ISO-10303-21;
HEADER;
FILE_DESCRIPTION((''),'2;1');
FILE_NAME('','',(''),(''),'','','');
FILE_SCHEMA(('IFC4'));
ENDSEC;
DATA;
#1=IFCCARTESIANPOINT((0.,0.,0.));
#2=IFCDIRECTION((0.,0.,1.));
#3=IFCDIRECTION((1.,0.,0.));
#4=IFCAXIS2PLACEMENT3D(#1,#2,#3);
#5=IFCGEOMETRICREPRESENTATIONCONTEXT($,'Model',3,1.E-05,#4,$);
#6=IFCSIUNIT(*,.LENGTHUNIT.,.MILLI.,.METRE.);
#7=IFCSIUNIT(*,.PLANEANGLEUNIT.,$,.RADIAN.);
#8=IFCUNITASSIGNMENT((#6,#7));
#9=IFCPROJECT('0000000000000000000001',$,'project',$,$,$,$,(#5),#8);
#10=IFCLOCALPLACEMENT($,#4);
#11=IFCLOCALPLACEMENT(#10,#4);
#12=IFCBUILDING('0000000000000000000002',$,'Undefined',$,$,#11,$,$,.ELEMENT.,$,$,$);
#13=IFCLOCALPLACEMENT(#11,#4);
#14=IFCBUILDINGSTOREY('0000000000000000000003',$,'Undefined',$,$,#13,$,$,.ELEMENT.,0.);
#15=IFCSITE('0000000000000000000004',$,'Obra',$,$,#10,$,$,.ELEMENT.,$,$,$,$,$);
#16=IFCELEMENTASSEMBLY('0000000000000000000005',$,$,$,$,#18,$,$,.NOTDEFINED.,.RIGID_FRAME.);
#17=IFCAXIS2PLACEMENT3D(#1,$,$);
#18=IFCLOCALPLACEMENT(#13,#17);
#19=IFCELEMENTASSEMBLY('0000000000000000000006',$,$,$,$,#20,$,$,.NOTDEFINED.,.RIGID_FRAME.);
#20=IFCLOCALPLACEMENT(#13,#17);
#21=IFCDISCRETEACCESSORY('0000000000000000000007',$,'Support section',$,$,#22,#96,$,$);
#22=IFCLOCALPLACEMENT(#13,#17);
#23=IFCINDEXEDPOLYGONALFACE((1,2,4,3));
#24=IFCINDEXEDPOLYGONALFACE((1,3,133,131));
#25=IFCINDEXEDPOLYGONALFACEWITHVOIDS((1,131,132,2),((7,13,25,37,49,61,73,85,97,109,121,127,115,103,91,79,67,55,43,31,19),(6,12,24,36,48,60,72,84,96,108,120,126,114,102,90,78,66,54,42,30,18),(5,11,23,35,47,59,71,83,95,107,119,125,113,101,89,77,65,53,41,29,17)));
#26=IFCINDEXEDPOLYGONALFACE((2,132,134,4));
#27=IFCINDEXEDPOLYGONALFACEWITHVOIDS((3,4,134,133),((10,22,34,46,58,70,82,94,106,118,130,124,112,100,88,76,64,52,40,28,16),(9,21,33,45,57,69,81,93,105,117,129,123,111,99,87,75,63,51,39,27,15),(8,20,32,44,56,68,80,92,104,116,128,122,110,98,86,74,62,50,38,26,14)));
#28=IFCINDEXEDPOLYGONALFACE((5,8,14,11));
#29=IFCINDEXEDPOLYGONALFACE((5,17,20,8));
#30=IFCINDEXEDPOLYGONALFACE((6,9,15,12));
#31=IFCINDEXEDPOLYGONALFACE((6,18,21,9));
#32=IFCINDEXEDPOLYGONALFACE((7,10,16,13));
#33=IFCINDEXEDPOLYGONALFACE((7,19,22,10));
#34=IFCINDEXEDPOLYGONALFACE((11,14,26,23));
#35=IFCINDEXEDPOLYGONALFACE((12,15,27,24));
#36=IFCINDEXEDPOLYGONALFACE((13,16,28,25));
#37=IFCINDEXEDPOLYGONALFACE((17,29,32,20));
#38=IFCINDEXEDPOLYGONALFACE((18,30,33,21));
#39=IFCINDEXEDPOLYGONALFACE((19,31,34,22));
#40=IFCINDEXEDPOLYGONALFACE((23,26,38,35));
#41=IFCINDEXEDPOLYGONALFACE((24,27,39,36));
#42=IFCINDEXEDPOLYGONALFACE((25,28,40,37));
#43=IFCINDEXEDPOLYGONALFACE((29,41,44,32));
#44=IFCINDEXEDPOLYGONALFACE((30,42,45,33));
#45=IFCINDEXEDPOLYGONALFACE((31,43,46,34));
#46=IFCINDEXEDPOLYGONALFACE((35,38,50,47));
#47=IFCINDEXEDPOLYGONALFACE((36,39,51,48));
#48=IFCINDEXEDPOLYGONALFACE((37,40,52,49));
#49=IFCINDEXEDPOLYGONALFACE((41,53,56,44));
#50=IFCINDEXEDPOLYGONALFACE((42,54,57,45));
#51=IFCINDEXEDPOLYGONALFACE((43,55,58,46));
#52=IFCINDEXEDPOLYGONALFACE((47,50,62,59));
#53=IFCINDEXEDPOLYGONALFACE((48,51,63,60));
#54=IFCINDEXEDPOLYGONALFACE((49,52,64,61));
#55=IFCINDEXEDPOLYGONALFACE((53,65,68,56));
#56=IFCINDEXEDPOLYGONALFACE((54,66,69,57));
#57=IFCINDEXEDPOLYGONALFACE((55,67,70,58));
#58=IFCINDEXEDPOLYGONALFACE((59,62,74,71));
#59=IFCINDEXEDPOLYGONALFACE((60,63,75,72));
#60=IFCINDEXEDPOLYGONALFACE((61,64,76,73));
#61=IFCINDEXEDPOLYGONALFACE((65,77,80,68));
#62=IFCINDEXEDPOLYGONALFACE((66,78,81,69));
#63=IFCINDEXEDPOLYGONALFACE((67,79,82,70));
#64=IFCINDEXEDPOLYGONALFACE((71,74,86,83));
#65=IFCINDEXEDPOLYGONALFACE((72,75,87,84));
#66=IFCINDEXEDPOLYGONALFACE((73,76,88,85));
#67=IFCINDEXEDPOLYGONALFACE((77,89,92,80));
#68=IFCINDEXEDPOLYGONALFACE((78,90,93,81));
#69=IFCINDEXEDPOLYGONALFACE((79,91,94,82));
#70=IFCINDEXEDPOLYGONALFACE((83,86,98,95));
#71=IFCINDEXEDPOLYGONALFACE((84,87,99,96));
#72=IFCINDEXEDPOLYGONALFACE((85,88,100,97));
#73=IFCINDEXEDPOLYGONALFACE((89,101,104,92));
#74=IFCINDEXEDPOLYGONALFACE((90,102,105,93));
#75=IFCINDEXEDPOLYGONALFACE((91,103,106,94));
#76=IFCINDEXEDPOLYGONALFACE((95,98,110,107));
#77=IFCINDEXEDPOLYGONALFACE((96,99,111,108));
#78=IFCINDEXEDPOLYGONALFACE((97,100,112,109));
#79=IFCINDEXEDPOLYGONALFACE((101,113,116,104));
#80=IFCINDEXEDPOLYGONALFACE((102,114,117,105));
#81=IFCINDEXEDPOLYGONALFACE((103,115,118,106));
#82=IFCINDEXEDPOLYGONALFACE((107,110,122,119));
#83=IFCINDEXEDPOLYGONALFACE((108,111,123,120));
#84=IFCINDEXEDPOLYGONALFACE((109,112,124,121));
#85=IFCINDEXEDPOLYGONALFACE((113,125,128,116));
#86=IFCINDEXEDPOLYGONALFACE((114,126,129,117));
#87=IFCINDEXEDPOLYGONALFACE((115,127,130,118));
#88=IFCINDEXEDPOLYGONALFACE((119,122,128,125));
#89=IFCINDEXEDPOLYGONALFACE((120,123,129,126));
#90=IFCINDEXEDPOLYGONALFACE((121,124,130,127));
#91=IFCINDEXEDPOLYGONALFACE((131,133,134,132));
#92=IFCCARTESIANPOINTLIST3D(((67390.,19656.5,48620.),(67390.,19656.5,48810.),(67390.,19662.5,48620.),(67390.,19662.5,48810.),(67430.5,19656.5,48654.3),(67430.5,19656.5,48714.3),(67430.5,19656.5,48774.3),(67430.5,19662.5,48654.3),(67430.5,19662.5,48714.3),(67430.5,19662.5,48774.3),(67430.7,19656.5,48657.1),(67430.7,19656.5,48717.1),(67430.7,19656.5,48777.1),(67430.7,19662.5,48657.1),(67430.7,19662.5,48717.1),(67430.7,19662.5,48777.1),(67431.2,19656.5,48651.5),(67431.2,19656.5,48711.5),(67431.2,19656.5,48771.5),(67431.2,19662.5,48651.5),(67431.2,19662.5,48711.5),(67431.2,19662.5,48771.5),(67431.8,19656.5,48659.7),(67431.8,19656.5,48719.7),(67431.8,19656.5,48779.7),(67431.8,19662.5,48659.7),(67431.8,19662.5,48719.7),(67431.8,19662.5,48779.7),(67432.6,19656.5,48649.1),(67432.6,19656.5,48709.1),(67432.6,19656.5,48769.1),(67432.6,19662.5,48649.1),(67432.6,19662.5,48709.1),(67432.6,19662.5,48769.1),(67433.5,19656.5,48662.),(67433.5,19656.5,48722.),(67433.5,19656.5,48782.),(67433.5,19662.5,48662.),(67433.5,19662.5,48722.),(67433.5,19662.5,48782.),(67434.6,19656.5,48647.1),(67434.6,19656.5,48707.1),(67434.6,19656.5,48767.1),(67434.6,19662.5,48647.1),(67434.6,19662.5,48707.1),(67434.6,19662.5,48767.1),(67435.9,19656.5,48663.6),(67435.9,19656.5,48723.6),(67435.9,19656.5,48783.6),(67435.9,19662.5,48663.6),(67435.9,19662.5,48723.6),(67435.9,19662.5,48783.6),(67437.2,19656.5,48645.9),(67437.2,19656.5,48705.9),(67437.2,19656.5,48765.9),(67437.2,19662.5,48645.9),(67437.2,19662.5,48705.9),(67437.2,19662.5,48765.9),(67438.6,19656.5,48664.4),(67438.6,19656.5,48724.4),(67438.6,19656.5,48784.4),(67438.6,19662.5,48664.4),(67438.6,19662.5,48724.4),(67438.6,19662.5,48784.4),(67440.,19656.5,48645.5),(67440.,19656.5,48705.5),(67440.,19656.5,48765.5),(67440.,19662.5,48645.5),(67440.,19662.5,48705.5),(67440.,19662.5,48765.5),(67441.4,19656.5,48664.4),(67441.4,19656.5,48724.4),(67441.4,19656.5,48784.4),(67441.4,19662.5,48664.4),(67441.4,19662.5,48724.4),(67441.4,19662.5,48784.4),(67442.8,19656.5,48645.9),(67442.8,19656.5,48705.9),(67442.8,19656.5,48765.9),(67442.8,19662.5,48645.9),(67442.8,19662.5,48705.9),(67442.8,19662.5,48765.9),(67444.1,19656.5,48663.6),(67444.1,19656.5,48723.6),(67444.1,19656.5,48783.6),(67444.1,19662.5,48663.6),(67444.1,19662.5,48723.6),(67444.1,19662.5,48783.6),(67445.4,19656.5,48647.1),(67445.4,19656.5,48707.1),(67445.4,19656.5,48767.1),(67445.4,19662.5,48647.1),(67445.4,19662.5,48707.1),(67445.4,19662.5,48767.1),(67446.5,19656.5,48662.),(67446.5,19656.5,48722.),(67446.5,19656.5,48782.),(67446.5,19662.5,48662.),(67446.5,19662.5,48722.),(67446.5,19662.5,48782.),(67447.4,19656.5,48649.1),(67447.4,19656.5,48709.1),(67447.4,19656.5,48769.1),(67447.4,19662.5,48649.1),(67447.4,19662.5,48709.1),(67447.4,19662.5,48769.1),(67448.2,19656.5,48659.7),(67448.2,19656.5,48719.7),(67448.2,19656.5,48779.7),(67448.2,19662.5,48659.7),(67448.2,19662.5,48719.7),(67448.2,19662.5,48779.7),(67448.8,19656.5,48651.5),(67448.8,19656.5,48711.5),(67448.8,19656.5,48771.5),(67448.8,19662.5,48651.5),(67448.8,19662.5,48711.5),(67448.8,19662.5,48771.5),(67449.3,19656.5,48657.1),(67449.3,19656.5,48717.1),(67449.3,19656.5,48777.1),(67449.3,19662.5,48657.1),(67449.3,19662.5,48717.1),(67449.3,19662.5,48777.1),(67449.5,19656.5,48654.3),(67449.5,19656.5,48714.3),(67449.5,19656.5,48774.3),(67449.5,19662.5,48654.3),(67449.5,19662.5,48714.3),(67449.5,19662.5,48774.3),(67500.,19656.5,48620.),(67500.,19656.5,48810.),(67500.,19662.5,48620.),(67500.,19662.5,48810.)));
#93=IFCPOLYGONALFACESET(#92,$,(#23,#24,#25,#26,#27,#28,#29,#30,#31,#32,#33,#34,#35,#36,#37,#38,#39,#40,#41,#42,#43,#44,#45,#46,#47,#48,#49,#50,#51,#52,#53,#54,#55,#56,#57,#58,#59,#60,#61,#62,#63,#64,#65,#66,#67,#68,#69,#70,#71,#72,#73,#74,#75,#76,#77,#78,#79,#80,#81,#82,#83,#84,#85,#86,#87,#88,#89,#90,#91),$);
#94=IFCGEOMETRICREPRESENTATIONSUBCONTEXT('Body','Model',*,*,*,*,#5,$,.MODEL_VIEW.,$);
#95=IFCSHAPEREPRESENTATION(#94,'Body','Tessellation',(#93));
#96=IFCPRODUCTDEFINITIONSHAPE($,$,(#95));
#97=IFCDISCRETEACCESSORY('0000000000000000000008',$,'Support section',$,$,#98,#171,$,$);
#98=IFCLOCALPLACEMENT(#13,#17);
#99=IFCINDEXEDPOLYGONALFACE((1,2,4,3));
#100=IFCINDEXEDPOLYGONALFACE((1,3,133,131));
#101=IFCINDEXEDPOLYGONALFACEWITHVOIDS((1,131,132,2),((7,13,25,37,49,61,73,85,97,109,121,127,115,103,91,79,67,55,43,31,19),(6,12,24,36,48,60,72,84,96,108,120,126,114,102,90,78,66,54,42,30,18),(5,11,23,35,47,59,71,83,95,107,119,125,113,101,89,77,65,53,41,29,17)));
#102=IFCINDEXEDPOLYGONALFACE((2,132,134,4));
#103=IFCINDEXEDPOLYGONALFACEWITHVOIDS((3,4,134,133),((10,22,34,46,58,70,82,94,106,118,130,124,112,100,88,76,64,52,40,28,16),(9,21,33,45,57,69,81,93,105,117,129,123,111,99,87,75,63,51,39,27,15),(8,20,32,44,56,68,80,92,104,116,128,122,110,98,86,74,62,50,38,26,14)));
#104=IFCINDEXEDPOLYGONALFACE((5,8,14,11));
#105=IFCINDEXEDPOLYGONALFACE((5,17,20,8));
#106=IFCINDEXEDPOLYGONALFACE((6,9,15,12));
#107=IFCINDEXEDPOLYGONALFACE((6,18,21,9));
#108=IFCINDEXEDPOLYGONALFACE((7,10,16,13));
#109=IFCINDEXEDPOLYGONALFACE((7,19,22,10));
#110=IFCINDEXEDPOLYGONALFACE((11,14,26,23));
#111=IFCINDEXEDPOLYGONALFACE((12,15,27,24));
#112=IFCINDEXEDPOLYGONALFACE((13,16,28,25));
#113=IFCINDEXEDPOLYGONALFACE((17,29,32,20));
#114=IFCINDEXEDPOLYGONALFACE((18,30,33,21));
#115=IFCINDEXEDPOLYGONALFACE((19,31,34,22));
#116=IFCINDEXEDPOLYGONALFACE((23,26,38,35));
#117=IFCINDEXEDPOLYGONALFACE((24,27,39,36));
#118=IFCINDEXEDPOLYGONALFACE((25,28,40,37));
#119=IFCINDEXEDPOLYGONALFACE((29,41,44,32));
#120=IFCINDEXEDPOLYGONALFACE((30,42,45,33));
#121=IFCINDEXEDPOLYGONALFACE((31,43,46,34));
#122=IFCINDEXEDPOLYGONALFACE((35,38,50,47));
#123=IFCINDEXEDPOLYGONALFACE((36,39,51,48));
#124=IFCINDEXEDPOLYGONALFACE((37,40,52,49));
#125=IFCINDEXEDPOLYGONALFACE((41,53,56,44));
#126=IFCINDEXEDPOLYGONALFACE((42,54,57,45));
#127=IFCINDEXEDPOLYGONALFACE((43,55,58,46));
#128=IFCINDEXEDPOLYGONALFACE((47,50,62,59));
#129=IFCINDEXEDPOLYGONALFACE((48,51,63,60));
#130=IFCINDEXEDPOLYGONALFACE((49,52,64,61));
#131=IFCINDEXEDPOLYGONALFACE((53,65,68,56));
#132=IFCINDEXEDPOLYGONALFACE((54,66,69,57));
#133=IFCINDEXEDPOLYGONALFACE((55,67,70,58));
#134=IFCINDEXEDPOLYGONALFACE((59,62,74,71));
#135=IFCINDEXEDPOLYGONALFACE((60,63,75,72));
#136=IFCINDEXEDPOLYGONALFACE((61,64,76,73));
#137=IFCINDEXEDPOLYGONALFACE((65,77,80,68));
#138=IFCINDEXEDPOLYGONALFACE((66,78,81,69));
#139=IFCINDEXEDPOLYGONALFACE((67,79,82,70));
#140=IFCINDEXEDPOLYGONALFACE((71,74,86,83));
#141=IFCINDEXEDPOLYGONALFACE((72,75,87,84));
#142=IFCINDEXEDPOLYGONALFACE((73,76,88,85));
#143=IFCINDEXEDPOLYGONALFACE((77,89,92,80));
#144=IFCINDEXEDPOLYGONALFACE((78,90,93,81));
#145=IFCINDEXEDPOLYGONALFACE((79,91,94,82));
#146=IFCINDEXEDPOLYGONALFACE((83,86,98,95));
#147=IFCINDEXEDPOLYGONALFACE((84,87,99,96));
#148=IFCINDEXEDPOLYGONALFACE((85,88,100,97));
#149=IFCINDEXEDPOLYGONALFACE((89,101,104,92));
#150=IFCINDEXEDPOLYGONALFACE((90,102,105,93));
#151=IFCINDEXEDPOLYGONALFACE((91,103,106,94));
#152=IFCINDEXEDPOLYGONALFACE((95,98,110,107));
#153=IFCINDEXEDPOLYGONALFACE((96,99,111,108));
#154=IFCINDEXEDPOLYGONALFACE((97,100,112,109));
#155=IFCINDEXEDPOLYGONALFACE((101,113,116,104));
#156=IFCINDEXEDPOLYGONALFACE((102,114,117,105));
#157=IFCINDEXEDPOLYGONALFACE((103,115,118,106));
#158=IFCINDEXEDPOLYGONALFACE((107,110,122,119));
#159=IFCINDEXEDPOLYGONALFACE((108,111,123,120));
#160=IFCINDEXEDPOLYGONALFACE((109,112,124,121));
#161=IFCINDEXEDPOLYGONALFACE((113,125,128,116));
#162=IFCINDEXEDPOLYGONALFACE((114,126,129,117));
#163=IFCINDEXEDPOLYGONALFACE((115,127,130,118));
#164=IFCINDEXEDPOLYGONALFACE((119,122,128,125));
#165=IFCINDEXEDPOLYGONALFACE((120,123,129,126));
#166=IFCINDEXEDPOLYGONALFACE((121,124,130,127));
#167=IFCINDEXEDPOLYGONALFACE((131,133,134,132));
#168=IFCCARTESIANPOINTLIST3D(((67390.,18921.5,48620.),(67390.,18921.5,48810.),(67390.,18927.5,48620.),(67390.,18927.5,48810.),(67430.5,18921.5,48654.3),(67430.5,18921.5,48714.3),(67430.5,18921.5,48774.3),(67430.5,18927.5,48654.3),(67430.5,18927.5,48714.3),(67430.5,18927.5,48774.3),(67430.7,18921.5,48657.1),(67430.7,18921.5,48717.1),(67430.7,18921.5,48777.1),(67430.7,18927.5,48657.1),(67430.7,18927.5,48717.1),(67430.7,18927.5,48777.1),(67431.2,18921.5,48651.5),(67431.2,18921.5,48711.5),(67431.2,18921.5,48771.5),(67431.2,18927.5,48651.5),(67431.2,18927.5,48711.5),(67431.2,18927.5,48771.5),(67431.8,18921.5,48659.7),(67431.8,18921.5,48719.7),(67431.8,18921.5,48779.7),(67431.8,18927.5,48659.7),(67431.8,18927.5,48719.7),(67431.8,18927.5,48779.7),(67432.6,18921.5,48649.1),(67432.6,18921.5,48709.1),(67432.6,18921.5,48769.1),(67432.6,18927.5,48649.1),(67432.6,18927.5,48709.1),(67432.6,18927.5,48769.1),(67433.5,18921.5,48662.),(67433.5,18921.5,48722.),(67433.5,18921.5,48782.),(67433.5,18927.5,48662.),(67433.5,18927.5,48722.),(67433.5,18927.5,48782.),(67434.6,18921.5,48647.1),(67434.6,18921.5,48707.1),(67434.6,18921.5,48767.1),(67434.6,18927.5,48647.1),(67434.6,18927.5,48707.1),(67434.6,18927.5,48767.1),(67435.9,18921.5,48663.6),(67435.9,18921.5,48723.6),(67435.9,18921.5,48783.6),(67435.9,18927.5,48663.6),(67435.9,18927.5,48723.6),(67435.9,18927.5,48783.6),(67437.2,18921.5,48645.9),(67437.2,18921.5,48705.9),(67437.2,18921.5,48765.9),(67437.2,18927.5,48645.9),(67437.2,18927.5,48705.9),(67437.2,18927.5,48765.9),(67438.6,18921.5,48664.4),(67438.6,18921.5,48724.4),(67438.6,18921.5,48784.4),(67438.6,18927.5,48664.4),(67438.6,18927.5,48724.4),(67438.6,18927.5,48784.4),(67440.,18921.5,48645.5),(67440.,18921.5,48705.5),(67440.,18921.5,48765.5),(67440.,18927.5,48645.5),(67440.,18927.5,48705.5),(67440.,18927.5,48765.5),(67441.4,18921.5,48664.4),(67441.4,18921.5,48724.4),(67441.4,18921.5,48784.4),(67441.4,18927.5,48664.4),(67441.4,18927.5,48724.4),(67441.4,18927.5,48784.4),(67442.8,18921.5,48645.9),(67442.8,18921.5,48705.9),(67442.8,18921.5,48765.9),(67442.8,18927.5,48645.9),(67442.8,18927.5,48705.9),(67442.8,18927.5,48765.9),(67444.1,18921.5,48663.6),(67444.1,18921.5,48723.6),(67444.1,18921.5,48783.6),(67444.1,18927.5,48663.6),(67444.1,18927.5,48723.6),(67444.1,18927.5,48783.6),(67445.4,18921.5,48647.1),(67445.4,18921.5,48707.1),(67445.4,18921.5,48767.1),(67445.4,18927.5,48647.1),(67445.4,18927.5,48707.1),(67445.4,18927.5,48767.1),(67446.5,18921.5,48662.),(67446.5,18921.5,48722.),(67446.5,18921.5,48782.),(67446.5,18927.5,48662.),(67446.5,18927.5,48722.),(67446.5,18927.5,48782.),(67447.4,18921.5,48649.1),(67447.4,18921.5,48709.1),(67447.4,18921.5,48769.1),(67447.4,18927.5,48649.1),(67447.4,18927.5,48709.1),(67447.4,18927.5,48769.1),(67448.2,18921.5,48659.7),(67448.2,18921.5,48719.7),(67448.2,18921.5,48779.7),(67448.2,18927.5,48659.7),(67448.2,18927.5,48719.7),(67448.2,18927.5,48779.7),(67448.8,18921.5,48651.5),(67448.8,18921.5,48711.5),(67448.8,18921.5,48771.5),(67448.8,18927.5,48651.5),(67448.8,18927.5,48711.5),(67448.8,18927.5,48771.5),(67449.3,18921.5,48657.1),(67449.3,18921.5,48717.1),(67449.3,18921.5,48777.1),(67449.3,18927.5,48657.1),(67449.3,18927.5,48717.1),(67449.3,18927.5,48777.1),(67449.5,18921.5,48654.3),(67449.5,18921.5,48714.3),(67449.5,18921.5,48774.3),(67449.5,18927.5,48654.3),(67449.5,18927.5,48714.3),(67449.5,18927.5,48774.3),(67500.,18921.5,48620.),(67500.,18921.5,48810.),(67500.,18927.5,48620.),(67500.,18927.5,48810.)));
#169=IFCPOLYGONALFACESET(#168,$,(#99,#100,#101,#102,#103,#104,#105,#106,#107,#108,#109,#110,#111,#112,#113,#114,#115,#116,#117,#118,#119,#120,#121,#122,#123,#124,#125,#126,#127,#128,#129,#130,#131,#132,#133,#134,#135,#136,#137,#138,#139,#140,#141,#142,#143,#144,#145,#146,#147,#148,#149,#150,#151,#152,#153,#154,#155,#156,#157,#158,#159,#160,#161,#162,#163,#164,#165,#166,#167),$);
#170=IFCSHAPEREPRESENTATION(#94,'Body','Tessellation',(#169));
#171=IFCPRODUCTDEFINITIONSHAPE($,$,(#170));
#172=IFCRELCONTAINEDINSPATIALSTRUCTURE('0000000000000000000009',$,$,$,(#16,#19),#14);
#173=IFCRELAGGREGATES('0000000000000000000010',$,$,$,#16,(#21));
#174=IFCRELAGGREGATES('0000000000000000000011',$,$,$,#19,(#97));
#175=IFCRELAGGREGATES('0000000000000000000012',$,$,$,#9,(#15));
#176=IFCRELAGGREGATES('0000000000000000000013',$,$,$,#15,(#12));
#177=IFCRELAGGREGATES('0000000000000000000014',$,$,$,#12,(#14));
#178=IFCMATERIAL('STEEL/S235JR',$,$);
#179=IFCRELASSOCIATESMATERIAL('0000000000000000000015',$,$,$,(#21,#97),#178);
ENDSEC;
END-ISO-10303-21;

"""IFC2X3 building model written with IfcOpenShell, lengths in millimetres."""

from ifc_helpers import new_model, si_unit, frame, origin_with_axes, origin_2d_with_axis, place, context, subcontext, project, spatial, rectangle, circle, extrude, source, transform, mapped, material, element, aggregate, save


model = new_model("IFC2X3")

# Units and contexts
model_context = context("Model", 3, precision=1e-05, world=origin_with_axes())
body_context = subcontext(model_context, "Body", "Model", "MODEL_VIEW")
ifc_project = project(units=[si_unit("LENGTHUNIT", "METRE", prefix="MILLI"), si_unit("PLANEANGLEUNIT", "RADIAN")], contexts=[model_context])

# Site, building, storey
site_placement = place(None, origin_with_axes())
site = spatial("IfcSite", under=ifc_project, at=site_placement, Name="Obra", CompositionType="ELEMENT")
building_placement = place(site_placement, origin_with_axes())
building = spatial("IfcBuilding", under=site, at=building_placement, Name="Undefined", CompositionType="ELEMENT")
storey_placement = place(building_placement, origin_with_axes())
storey = spatial("IfcBuildingStorey", under=building, at=storey_placement, Name="Undefined", CompositionType="ELEMENT", Elevation=0.0)

# Element assemblies
ifc_material_1 = material(Name="STEEL/S235JR")
assembly_1_placement = place(storey_placement, origin_with_axes())
assembly_1 = element("IfcElementAssembly", 1, at=assembly_1_placement, inside=storey, AssemblyPlace="NOTDEFINED", PredefinedType="RIGID_FRAME")
assembly_2_placement = place(storey_placement, origin_with_axes())
assembly_2 = element("IfcElementAssembly", 2, at=assembly_2_placement, inside=storey, AssemblyPlace="NOTDEFINED", PredefinedType="RIGID_FRAME")

# Discrete accessories, openings
shared_shape_1 = source(origin_with_axes(), body_context, "Body", "SweptSolid", [
    extrude(circle(Radius=9.5, at=origin_2d_with_axis()), frame((0.0, -9.2, 0.0), z_axis=(0.0, 1.0, 0.0), x_axis=(1.0, 0.0, 0.0)), (0.0, 0.0, 1.0), 6.2),
])
discrete_accessory_1_placement = place(assembly_1_placement, frame((67445.0, 19659.5, 48620.0), z_axis=(0.0, 0.0, 1.0), x_axis=(1.0, 0.0, 0.0)))
discrete_accessory_1 = element("IfcDiscreteAccessory", 3, at=discrete_accessory_1_placement, material=ifc_material_1, Name="Support section", context=body_context, shape_type="SweptSolid", body=[
    extrude(rectangle(XDim=6.0, YDim=110.0, at=origin_2d_with_axis()), frame((0.0, 0.0, 190.0), z_axis=(0.0, 0.0, -1.0), x_axis=(0.0, 1.0, 0.0)), (0.0, 0.0, 1.0), 190.0),
])
opening_1_placement = place(assembly_1_placement, frame((67490.0, 19653.4, 48835.0), z_axis=(-1.0, 0.0, 0.0), x_axis=(0.0, 0.0, -1.0)))
element("IfcOpeningElement", 4, at=opening_1_placement, cuts=discrete_accessory_1, ObjectType="Opening", context=body_context, shape_type="MappedRepresentation", body=[
    mapped(shared_shape_1, transform((60.0, 0.0, 50.0))),
    mapped(shared_shape_1, transform((120.0, 0.0, 50.0))),
    mapped(shared_shape_1, transform((180.0, 0.0, 50.0))),
])
aggregate(assembly_1, [discrete_accessory_1])
discrete_accessory_2_placement = place(assembly_2_placement, frame((67445.0, 18924.5, 48620.0), z_axis=(0.0, 0.0, 1.0), x_axis=(1.0, 0.0, 0.0)))
discrete_accessory_2 = element("IfcDiscreteAccessory", 5, at=discrete_accessory_2_placement, material=ifc_material_1, Name="Support section", context=body_context, shape_type="SweptSolid", body=[
    extrude(rectangle(XDim=6.0, YDim=110.0, at=origin_2d_with_axis()), frame((0.0, 0.0, 190.0), z_axis=(0.0, 0.0, -1.0), x_axis=(0.0, 1.0, 0.0)), (0.0, 0.0, 1.0), 190.0),
])
opening_2_placement = place(assembly_2_placement, frame((67490.0, 18918.4, 48835.0), z_axis=(-1.0, 0.0, 0.0), x_axis=(0.0, 0.0, -1.0)))
element("IfcOpeningElement", 6, at=opening_2_placement, cuts=discrete_accessory_2, ObjectType="Opening", context=body_context, shape_type="MappedRepresentation", body=[
    mapped(shared_shape_1, transform((60.0, 0.0, 50.0))),
    mapped(shared_shape_1, transform((120.0, 0.0, 50.0))),
    mapped(shared_shape_1, transform((180.0, 0.0, 50.0))),
])
aggregate(assembly_2, [discrete_accessory_2])

save(model, "model.ifc")
